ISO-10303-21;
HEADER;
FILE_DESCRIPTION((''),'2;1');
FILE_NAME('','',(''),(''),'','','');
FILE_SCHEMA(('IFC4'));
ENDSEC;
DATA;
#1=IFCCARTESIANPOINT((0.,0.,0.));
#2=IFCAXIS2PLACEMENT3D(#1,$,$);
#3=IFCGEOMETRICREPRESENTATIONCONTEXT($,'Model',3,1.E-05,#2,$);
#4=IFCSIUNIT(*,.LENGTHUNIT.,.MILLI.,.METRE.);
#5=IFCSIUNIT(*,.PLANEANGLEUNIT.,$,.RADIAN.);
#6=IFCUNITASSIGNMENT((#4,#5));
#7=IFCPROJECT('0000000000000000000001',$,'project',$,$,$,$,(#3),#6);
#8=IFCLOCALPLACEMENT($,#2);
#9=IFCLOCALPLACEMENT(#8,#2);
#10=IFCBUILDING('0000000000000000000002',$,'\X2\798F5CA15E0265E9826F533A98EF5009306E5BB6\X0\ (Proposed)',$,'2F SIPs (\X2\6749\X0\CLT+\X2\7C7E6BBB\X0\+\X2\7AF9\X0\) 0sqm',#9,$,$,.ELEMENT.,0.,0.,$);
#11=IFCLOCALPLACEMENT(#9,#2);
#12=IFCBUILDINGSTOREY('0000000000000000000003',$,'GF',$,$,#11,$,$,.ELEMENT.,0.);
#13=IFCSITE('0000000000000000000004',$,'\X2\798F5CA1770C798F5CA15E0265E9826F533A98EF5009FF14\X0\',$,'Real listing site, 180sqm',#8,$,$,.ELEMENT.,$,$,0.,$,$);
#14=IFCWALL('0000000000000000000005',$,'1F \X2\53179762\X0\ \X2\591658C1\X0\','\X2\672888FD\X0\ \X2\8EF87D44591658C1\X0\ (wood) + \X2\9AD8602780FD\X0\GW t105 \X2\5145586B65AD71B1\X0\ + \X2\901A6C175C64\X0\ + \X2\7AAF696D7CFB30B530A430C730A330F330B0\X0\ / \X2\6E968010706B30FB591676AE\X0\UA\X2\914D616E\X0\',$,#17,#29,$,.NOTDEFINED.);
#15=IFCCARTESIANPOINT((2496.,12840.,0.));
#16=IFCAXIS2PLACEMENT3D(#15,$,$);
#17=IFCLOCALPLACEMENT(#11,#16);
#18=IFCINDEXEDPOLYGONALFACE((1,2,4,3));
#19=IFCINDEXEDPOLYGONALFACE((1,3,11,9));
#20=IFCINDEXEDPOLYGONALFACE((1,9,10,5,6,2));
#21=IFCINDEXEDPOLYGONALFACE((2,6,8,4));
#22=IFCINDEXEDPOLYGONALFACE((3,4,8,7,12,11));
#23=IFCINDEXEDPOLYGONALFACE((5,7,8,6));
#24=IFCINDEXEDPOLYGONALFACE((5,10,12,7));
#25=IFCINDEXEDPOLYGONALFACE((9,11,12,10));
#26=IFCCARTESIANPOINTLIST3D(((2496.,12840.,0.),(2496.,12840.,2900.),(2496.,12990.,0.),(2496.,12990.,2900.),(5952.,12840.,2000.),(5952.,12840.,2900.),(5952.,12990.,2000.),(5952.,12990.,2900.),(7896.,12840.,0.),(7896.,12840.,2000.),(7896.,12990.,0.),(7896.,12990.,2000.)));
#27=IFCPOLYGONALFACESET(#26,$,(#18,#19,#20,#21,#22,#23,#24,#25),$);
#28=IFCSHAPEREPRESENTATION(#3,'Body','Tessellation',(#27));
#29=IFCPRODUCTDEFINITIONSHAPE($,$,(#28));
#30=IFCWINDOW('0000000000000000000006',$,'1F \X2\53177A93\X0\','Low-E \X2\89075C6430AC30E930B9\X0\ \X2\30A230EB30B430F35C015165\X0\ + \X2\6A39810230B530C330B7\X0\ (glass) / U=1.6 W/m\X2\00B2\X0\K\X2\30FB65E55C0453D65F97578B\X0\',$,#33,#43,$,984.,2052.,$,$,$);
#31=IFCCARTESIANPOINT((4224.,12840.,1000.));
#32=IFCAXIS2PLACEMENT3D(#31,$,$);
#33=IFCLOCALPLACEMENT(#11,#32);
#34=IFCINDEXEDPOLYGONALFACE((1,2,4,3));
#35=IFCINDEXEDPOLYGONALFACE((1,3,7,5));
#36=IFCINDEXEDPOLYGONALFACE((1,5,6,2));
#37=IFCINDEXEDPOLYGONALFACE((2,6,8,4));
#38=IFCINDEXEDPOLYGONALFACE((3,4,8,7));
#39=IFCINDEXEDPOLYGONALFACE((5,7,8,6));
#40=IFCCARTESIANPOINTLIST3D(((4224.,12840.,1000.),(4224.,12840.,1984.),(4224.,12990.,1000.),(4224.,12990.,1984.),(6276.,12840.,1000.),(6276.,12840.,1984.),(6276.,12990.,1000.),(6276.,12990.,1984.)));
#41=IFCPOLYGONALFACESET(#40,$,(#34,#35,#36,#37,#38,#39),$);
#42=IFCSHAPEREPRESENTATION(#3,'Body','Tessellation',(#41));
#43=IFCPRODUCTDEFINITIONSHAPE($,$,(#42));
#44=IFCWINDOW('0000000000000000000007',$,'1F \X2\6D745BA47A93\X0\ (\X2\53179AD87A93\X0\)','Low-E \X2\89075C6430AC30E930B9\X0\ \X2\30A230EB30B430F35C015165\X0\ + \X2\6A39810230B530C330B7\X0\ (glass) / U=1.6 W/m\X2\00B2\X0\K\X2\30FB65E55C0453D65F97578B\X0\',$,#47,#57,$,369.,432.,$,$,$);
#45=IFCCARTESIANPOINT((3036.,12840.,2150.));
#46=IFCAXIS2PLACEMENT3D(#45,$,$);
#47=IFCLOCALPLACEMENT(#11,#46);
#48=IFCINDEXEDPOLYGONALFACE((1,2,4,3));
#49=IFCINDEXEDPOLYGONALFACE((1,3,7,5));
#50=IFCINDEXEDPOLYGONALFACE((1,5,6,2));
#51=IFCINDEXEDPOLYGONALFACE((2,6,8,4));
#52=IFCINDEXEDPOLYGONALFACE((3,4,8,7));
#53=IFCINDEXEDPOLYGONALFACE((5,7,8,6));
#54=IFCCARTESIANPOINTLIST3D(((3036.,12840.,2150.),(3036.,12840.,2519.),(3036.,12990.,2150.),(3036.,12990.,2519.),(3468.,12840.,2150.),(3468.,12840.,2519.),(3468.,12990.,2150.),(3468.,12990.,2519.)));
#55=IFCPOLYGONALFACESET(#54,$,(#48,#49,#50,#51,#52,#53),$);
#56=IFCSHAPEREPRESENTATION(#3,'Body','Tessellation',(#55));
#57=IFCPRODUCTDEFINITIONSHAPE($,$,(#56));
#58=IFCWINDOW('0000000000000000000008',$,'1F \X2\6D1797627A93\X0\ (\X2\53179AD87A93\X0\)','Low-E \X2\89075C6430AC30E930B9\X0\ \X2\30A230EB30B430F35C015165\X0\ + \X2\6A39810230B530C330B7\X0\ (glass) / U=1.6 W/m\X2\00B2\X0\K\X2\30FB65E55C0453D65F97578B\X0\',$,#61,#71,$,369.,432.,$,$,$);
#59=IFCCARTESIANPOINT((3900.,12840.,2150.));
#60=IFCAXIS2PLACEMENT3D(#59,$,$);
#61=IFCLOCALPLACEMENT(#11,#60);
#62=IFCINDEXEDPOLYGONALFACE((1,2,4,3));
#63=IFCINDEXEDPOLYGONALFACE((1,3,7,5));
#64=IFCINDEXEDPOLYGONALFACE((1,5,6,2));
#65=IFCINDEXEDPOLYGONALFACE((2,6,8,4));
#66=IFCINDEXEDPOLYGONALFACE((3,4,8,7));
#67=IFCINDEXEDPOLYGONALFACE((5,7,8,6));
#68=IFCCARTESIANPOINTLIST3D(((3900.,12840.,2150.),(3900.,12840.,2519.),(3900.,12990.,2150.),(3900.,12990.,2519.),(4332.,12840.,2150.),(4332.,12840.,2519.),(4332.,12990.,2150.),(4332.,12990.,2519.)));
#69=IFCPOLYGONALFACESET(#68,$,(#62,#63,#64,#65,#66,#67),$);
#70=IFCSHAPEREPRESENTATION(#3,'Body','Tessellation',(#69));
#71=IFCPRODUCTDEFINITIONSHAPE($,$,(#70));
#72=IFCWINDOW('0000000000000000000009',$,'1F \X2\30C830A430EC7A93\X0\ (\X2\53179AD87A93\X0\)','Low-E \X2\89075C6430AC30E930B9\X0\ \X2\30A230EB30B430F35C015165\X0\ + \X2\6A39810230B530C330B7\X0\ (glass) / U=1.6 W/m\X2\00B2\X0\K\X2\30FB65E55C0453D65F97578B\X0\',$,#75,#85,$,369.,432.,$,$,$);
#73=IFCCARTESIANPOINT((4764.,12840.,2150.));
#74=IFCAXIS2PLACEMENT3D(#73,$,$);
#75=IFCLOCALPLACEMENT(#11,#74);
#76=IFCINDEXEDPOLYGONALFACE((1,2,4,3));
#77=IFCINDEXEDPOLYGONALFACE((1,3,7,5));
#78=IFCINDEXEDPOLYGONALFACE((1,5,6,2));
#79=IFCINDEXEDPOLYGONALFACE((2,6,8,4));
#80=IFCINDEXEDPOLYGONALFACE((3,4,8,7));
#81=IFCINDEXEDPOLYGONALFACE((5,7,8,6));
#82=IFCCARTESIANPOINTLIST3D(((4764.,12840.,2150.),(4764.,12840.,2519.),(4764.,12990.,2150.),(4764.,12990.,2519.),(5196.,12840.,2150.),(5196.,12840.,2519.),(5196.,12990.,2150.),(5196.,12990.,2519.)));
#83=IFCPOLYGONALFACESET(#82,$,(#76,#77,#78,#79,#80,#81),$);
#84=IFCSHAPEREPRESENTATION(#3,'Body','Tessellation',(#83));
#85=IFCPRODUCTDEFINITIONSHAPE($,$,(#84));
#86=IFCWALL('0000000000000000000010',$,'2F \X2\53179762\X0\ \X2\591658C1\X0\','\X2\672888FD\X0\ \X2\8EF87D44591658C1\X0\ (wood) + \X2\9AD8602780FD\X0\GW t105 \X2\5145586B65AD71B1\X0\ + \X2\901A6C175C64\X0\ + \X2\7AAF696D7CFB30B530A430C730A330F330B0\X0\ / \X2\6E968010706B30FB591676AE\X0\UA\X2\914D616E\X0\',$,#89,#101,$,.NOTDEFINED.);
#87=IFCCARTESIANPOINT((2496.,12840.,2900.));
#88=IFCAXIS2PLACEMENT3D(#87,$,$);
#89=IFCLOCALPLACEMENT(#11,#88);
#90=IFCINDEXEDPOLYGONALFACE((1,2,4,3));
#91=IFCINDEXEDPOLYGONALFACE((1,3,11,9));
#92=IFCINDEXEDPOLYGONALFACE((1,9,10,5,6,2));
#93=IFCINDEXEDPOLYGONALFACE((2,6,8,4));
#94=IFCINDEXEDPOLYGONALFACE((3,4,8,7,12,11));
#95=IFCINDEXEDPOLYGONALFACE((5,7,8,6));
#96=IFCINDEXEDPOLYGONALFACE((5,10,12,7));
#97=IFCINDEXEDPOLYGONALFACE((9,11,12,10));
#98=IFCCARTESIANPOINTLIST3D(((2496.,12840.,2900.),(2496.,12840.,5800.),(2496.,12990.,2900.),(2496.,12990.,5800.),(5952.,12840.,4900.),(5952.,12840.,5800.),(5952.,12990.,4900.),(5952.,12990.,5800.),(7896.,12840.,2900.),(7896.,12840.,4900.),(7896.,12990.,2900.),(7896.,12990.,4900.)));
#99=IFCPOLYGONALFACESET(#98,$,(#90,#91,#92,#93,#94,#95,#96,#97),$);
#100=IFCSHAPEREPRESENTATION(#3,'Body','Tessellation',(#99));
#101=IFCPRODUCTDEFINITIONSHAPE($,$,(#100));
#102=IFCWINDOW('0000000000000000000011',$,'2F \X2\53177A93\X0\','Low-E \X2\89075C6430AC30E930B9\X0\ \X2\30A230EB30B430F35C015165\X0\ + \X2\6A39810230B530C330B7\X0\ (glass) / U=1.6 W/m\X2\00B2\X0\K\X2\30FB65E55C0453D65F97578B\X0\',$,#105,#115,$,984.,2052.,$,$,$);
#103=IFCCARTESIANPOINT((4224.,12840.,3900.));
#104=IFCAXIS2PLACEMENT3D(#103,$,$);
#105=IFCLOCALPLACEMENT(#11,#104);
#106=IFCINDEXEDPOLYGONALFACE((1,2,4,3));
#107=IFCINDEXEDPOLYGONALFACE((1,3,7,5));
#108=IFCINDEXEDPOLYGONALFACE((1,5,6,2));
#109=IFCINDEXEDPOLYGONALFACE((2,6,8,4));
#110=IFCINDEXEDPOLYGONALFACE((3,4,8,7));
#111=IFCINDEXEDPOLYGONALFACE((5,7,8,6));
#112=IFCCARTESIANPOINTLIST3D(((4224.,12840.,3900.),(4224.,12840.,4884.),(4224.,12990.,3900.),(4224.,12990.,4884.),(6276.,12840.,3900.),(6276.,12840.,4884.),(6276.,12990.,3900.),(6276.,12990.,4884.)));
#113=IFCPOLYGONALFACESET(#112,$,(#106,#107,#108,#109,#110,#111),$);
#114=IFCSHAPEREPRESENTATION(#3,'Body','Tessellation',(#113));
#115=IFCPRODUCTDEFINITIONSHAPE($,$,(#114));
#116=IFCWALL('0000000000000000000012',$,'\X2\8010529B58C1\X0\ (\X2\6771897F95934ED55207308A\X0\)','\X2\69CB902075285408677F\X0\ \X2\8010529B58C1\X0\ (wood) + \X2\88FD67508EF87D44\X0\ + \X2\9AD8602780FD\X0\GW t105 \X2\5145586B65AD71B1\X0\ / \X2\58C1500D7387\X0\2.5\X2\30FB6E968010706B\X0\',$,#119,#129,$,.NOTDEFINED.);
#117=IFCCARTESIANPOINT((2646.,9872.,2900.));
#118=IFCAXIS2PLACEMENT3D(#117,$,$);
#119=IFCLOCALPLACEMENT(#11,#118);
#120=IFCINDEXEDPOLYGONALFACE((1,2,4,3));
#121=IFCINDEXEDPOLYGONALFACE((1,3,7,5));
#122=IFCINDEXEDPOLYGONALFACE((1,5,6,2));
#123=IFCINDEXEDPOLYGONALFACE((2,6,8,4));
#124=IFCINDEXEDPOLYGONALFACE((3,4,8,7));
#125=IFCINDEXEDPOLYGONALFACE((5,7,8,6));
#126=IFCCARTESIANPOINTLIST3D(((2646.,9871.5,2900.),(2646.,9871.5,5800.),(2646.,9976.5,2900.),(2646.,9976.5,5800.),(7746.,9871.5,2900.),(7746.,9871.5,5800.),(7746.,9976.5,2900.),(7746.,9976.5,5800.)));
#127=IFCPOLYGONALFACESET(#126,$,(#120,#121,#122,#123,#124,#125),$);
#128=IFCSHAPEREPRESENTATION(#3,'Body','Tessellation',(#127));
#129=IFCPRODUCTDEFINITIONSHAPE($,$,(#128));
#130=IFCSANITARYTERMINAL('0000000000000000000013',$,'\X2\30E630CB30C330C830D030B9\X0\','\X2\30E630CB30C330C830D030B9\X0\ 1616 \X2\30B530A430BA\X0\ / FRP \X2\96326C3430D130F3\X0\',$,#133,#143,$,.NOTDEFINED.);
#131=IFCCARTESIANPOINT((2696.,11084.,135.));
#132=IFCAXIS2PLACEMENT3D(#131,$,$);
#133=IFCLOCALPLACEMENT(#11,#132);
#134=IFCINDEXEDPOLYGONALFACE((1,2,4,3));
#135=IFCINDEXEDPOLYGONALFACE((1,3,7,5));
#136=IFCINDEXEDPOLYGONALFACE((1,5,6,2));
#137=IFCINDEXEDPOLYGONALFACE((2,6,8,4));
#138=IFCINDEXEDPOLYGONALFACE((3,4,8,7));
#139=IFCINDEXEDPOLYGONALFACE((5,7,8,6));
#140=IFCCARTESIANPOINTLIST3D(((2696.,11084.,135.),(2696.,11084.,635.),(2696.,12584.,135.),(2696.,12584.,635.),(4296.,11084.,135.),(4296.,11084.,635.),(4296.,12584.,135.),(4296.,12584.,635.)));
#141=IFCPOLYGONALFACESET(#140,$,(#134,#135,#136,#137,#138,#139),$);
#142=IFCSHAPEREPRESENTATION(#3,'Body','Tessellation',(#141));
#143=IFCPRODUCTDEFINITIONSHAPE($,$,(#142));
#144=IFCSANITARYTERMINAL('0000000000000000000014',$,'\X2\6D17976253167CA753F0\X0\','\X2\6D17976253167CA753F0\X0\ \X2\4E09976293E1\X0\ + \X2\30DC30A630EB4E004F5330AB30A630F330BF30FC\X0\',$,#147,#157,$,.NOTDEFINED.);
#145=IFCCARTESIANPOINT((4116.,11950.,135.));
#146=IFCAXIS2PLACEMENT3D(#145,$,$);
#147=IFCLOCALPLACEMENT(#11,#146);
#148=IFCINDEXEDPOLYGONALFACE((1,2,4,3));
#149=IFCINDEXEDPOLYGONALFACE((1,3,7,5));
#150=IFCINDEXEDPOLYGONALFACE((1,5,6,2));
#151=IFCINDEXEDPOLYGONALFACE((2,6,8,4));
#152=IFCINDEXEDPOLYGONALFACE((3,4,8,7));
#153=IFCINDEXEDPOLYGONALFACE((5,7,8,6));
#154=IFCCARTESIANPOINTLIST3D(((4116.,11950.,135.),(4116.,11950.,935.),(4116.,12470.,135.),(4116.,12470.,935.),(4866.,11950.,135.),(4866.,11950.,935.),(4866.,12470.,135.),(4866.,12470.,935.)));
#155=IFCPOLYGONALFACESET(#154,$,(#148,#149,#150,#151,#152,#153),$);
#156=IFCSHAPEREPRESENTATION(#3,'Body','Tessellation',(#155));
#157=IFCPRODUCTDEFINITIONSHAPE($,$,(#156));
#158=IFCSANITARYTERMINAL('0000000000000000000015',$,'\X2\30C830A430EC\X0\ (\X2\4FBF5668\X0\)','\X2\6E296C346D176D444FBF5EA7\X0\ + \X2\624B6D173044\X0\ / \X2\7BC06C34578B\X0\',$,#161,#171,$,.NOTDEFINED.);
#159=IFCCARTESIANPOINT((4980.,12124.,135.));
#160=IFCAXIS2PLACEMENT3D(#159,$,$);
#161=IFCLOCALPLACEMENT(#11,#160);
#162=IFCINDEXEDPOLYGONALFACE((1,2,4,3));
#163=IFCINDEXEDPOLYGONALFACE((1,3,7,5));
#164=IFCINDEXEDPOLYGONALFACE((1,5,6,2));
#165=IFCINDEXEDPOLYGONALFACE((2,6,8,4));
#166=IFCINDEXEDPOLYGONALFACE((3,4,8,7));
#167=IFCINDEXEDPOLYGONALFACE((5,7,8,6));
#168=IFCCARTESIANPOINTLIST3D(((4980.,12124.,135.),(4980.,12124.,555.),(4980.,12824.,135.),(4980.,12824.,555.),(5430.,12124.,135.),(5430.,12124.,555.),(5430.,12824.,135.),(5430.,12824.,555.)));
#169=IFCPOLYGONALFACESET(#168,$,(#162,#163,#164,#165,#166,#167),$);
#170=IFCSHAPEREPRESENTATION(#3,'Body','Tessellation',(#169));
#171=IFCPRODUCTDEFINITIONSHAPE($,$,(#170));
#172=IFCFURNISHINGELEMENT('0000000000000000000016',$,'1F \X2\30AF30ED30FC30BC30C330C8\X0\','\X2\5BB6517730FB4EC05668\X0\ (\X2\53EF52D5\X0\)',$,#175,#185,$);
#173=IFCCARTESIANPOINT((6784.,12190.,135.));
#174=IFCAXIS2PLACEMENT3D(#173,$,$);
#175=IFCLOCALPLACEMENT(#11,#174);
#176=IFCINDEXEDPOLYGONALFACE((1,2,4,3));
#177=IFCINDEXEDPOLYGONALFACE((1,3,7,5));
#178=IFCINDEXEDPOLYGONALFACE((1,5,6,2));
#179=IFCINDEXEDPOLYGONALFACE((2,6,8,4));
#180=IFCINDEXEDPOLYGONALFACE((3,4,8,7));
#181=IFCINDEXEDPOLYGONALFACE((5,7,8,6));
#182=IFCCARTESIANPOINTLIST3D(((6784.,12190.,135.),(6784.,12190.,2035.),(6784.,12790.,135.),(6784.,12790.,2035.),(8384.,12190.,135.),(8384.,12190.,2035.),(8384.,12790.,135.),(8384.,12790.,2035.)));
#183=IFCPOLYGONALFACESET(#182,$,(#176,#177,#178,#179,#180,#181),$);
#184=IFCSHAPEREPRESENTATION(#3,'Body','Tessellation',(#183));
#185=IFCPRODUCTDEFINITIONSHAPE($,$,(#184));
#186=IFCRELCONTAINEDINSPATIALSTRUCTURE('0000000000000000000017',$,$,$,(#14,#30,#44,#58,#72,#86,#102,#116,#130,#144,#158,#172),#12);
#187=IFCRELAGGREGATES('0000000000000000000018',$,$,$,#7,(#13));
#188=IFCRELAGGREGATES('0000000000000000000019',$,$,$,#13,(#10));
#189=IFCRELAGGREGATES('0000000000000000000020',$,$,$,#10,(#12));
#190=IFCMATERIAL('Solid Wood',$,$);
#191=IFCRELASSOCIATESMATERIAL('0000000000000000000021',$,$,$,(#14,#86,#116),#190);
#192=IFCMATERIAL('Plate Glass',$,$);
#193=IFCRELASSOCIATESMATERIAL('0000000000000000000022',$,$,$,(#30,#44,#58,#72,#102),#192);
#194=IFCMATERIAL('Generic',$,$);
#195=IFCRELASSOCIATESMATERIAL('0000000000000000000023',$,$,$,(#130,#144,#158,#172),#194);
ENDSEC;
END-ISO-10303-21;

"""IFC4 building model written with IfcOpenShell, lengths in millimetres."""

from ifc_helpers import new_model, si_unit, frame, frame_2d, origin, place, context, project, spatial, rectangle, extrude, material, element, fill, save


model = new_model("IFC4")

# Units and contexts
model_context = context("Model", 3, precision=1e-05, world=origin())
ifc_project = project(units=[si_unit("LENGTHUNIT", "METRE", prefix="MILLI"), si_unit("PLANEANGLEUNIT", "RADIAN")], contexts=[model_context])

# Site, building, storey
site_placement = place(None, origin())
site = spatial("IfcSite", under=ifc_project, at=site_placement, Name="福岡県福岡市早良区飯倉４", ObjectType="Real listing site, 180sqm", CompositionType="ELEMENT", RefElevation=0.0)
building_placement = place(site_placement, origin())
building = spatial("IfcBuilding", under=site, at=building_placement, Name="福岡市早良区飯倉の家 (Proposed)", ObjectType="2F SIPs (杉CLT+籾殻+竹) 0sqm", CompositionType="ELEMENT", ElevationOfRefHeight=0.0, ElevationOfTerrain=0.0)
storey_placement = place(building_placement, origin())
storey = spatial("IfcBuildingStorey", under=building, at=storey_placement, Name="GF", CompositionType="ELEMENT", Elevation=0.0)

# Wall, openings, windows
ifc_material_1 = material(Name="Solid Wood")
wall_1_placement = place(storey_placement, frame((2496.0, 12840.0, 0.0)))
wall_1 = element("IfcWall", 1, at=wall_1_placement, inside=storey, material=ifc_material_1, Name="1F 北面 外壁", Description="木製 軸組外壁 (wood) + 高性能GW t105 充填断熱 + 通気層 + 窯業系サイディング / 準耐火・外皮UA配慮", PredefinedType="NOTDEFINED", context=model_context, shape_type="SweptSolid", body=[
    extrude(rectangle(XDim=5400.0, YDim=150.0, at=frame_2d((2700.0, 75.0))), frame((2496.0, 12840.0, 0.0)), (0.0, 0.0, 1.0), 2900.0),
])
opening_1_placement = place(storey_placement, frame((4224.0, 12840.0, 1000.0)))
opening_1 = element("IfcOpeningElement", 2, at=opening_1_placement, cuts=wall_1, PredefinedType="NOTDEFINED", context=model_context, shape_type="SweptSolid", body=[
    extrude(rectangle(XDim=2052.0, YDim=150.0, at=frame_2d((1026.0, 75.0))), frame((4224.0, 12840.0, 1000.0)), (0.0, 0.0, 1.0), 984.0),
])
opening_2_placement = place(storey_placement, frame((3036.0, 12840.0, 2150.0)))
opening_2 = element("IfcOpeningElement", 3, at=opening_2_placement, cuts=wall_1, PredefinedType="NOTDEFINED", context=model_context, shape_type="SweptSolid", body=[
    extrude(rectangle(XDim=432.0, YDim=150.0, at=frame_2d((216.0, 75.0))), frame((3036.0, 12840.0, 2150.0)), (0.0, 0.0, 1.0), 369.0),
])
opening_3_placement = place(storey_placement, frame((3900.0, 12840.0, 2150.0)))
opening_3 = element("IfcOpeningElement", 4, at=opening_3_placement, cuts=wall_1, PredefinedType="NOTDEFINED", context=model_context, shape_type="SweptSolid", body=[
    extrude(rectangle(XDim=432.0, YDim=150.0, at=frame_2d((216.0, 75.0))), frame((3900.0, 12840.0, 2150.0)), (0.0, 0.0, 1.0), 369.0),
])
opening_4_placement = place(storey_placement, frame((4764.0, 12840.0, 2150.0)))
opening_4 = element("IfcOpeningElement", 5, at=opening_4_placement, cuts=wall_1, PredefinedType="NOTDEFINED", context=model_context, shape_type="SweptSolid", body=[
    extrude(rectangle(XDim=432.0, YDim=150.0, at=frame_2d((216.0, 75.0))), frame((4764.0, 12840.0, 2150.0)), (0.0, 0.0, 1.0), 369.0),
])
ifc_material_2 = material(Name="Plate Glass")
window_1_placement = place(storey_placement, frame((4224.0, 12840.0, 1000.0)))
window_1 = element("IfcWindow", 6, at=window_1_placement, inside=storey, material=ifc_material_2, Name="1F 北窓", Description="Low-E 複層ガラス アルゴン封入 + 樹脂サッシ (glass) / U=1.6 W/m²K・日射取得型", OverallHeight=984.0, OverallWidth=2052.0, context=model_context, shape_type="SweptSolid", body=[
    extrude(rectangle(XDim=2052.0, YDim=150.0, at=frame_2d((1026.0, 75.0))), frame((4224.0, 12840.0, 1000.0)), (0.0, 0.0, 1.0), 984.0),
])
fill(opening_1, window_1)
window_2_placement = place(storey_placement, frame((3036.0, 12840.0, 2150.0)))
window_2 = element("IfcWindow", 7, at=window_2_placement, inside=storey, material=ifc_material_2, Name="1F 浴室窓 (北高窓)", Description="Low-E 複層ガラス アルゴン封入 + 樹脂サッシ (glass) / U=1.6 W/m²K・日射取得型", OverallHeight=369.0, OverallWidth=432.0, context=model_context, shape_type="SweptSolid", body=[
    extrude(rectangle(XDim=432.0, YDim=150.0, at=frame_2d((216.0, 75.0))), frame((3036.0, 12840.0, 2150.0)), (0.0, 0.0, 1.0), 369.0),
])
fill(opening_2, window_2)
window_3_placement = place(storey_placement, frame((3900.0, 12840.0, 2150.0)))
window_3 = element("IfcWindow", 8, at=window_3_placement, inside=storey, material=ifc_material_2, Name="1F 洗面窓 (北高窓)", Description="Low-E 複層ガラス アルゴン封入 + 樹脂サッシ (glass) / U=1.6 W/m²K・日射取得型", OverallHeight=369.0, OverallWidth=432.0, context=model_context, shape_type="SweptSolid", body=[
    extrude(rectangle(XDim=432.0, YDim=150.0, at=frame_2d((216.0, 75.0))), frame((3900.0, 12840.0, 2150.0)), (0.0, 0.0, 1.0), 369.0),
])
fill(opening_3, window_3)
window_4_placement = place(storey_placement, frame((4764.0, 12840.0, 2150.0)))
window_4 = element("IfcWindow", 9, at=window_4_placement, inside=storey, material=ifc_material_2, Name="1F トイレ窓 (北高窓)", Description="Low-E 複層ガラス アルゴン封入 + 樹脂サッシ (glass) / U=1.6 W/m²K・日射取得型", OverallHeight=369.0, OverallWidth=432.0, context=model_context, shape_type="SweptSolid", body=[
    extrude(rectangle(XDim=432.0, YDim=150.0, at=frame_2d((216.0, 75.0))), frame((4764.0, 12840.0, 2150.0)), (0.0, 0.0, 1.0), 369.0),
])
fill(opening_4, window_4)

# Wall, opening, window
wall_2_placement = place(storey_placement, frame((2496.0, 12840.0, 2900.0)))
wall_2 = element("IfcWall", 10, at=wall_2_placement, inside=storey, material=ifc_material_1, Name="2F 北面 外壁", Description="木製 軸組外壁 (wood) + 高性能GW t105 充填断熱 + 通気層 + 窯業系サイディング / 準耐火・外皮UA配慮", PredefinedType="NOTDEFINED", context=model_context, shape_type="SweptSolid", body=[
    extrude(rectangle(XDim=5400.0, YDim=150.0, at=frame_2d((2700.0, 75.0))), frame((2496.0, 12840.0, 2900.0)), (0.0, 0.0, 1.0), 2900.0),
])
opening_5_placement = place(storey_placement, frame((4224.0, 12840.0, 3900.0)))
opening_5 = element("IfcOpeningElement", 11, at=opening_5_placement, cuts=wall_2, PredefinedType="NOTDEFINED", context=model_context, shape_type="SweptSolid", body=[
    extrude(rectangle(XDim=2052.0, YDim=150.0, at=frame_2d((1026.0, 75.0))), frame((4224.0, 12840.0, 3900.0)), (0.0, 0.0, 1.0), 984.0),
])
window_5_placement = place(storey_placement, frame((4224.0, 12840.0, 3900.0)))
window_5 = element("IfcWindow", 12, at=window_5_placement, inside=storey, material=ifc_material_2, Name="2F 北窓", Description="Low-E 複層ガラス アルゴン封入 + 樹脂サッシ (glass) / U=1.6 W/m²K・日射取得型", OverallHeight=984.0, OverallWidth=2052.0, context=model_context, shape_type="SweptSolid", body=[
    extrude(rectangle(XDim=2052.0, YDim=150.0, at=frame_2d((1026.0, 75.0))), frame((4224.0, 12840.0, 3900.0)), (0.0, 0.0, 1.0), 984.0),
])
fill(opening_5, window_5)

# Wall
wall_3_placement = place(storey_placement, frame((2646.0, 9872.0, 2900.0)))
element("IfcWall", 13, at=wall_3_placement, inside=storey, material=ifc_material_1, Name="耐力壁 (東西間仕切り)", Description="構造用合板 耐力壁 (wood) + 製材軸組 + 高性能GW t105 充填断熱 / 壁倍率2.5・準耐火", PredefinedType="NOTDEFINED", context=model_context, shape_type="SweptSolid", body=[
    extrude(rectangle(XDim=5100.0, YDim=105.0, at=frame_2d((2550.0, 52.0))), frame((2646.0, 9872.0, 2900.0)), (0.0, 0.0, 1.0), 2900.0),
])

# Sanitary terminals
ifc_material_3 = material(Name="Generic")
sanitary_terminal_1_placement = place(storey_placement, frame((2696.0, 11084.0, 135.0)))
element("IfcSanitaryTerminal", 14, at=sanitary_terminal_1_placement, inside=storey, material=ifc_material_3, Name="ユニットバス", Description="ユニットバス 1616 サイズ / FRP 防水パン", PredefinedType="NOTDEFINED", context=model_context, shape_type="SweptSolid", body=[
    extrude(rectangle(XDim=1600.0, YDim=1500.0, at=frame_2d((800.0, 750.0))), frame((2696.0, 11084.0, 135.0)), (0.0, 0.0, 1.0), 500.0),
])
sanitary_terminal_2_placement = place(storey_placement, frame((4116.0, 11950.0, 135.0)))
element("IfcSanitaryTerminal", 15, at=sanitary_terminal_2_placement, inside=storey, material=ifc_material_3, Name="洗面化粧台", Description="洗面化粧台 三面鏡 + ボウル一体カウンター", PredefinedType="NOTDEFINED", context=model_context, shape_type="SweptSolid", body=[
    extrude(rectangle(XDim=750.0, YDim=520.0, at=frame_2d((375.0, 260.0))), frame((4116.0, 11950.0, 135.0)), (0.0, 0.0, 1.0), 800.0),
])
sanitary_terminal_3_placement = place(storey_placement, frame((4980.0, 12124.0, 135.0)))
element("IfcSanitaryTerminal", 16, at=sanitary_terminal_3_placement, inside=storey, material=ifc_material_3, Name="トイレ (便器)", Description="温水洗浄便座 + 手洗い / 節水型", PredefinedType="NOTDEFINED", context=model_context, shape_type="SweptSolid", body=[
    extrude(rectangle(XDim=450.0, YDim=700.0, at=frame_2d((225.0, 350.0))), frame((4980.0, 12124.0, 135.0)), (0.0, 0.0, 1.0), 420.0),
])

# Furnishing element
furnishing_1_placement = place(storey_placement, frame((6784.0, 12190.0, 135.0)))
element("IfcFurnishingElement", 17, at=furnishing_1_placement, inside=storey, material=ifc_material_3, Name="1F クローゼット", Description="家具・什器 (可動)", context=model_context, shape_type="SweptSolid", body=[
    extrude(rectangle(XDim=1600.0, YDim=600.0, at=frame_2d((800.0, 300.0))), frame((6784.0, 12190.0, 135.0)), (0.0, 0.0, 1.0), 1900.0),
])

save(model, "model.ifc")
